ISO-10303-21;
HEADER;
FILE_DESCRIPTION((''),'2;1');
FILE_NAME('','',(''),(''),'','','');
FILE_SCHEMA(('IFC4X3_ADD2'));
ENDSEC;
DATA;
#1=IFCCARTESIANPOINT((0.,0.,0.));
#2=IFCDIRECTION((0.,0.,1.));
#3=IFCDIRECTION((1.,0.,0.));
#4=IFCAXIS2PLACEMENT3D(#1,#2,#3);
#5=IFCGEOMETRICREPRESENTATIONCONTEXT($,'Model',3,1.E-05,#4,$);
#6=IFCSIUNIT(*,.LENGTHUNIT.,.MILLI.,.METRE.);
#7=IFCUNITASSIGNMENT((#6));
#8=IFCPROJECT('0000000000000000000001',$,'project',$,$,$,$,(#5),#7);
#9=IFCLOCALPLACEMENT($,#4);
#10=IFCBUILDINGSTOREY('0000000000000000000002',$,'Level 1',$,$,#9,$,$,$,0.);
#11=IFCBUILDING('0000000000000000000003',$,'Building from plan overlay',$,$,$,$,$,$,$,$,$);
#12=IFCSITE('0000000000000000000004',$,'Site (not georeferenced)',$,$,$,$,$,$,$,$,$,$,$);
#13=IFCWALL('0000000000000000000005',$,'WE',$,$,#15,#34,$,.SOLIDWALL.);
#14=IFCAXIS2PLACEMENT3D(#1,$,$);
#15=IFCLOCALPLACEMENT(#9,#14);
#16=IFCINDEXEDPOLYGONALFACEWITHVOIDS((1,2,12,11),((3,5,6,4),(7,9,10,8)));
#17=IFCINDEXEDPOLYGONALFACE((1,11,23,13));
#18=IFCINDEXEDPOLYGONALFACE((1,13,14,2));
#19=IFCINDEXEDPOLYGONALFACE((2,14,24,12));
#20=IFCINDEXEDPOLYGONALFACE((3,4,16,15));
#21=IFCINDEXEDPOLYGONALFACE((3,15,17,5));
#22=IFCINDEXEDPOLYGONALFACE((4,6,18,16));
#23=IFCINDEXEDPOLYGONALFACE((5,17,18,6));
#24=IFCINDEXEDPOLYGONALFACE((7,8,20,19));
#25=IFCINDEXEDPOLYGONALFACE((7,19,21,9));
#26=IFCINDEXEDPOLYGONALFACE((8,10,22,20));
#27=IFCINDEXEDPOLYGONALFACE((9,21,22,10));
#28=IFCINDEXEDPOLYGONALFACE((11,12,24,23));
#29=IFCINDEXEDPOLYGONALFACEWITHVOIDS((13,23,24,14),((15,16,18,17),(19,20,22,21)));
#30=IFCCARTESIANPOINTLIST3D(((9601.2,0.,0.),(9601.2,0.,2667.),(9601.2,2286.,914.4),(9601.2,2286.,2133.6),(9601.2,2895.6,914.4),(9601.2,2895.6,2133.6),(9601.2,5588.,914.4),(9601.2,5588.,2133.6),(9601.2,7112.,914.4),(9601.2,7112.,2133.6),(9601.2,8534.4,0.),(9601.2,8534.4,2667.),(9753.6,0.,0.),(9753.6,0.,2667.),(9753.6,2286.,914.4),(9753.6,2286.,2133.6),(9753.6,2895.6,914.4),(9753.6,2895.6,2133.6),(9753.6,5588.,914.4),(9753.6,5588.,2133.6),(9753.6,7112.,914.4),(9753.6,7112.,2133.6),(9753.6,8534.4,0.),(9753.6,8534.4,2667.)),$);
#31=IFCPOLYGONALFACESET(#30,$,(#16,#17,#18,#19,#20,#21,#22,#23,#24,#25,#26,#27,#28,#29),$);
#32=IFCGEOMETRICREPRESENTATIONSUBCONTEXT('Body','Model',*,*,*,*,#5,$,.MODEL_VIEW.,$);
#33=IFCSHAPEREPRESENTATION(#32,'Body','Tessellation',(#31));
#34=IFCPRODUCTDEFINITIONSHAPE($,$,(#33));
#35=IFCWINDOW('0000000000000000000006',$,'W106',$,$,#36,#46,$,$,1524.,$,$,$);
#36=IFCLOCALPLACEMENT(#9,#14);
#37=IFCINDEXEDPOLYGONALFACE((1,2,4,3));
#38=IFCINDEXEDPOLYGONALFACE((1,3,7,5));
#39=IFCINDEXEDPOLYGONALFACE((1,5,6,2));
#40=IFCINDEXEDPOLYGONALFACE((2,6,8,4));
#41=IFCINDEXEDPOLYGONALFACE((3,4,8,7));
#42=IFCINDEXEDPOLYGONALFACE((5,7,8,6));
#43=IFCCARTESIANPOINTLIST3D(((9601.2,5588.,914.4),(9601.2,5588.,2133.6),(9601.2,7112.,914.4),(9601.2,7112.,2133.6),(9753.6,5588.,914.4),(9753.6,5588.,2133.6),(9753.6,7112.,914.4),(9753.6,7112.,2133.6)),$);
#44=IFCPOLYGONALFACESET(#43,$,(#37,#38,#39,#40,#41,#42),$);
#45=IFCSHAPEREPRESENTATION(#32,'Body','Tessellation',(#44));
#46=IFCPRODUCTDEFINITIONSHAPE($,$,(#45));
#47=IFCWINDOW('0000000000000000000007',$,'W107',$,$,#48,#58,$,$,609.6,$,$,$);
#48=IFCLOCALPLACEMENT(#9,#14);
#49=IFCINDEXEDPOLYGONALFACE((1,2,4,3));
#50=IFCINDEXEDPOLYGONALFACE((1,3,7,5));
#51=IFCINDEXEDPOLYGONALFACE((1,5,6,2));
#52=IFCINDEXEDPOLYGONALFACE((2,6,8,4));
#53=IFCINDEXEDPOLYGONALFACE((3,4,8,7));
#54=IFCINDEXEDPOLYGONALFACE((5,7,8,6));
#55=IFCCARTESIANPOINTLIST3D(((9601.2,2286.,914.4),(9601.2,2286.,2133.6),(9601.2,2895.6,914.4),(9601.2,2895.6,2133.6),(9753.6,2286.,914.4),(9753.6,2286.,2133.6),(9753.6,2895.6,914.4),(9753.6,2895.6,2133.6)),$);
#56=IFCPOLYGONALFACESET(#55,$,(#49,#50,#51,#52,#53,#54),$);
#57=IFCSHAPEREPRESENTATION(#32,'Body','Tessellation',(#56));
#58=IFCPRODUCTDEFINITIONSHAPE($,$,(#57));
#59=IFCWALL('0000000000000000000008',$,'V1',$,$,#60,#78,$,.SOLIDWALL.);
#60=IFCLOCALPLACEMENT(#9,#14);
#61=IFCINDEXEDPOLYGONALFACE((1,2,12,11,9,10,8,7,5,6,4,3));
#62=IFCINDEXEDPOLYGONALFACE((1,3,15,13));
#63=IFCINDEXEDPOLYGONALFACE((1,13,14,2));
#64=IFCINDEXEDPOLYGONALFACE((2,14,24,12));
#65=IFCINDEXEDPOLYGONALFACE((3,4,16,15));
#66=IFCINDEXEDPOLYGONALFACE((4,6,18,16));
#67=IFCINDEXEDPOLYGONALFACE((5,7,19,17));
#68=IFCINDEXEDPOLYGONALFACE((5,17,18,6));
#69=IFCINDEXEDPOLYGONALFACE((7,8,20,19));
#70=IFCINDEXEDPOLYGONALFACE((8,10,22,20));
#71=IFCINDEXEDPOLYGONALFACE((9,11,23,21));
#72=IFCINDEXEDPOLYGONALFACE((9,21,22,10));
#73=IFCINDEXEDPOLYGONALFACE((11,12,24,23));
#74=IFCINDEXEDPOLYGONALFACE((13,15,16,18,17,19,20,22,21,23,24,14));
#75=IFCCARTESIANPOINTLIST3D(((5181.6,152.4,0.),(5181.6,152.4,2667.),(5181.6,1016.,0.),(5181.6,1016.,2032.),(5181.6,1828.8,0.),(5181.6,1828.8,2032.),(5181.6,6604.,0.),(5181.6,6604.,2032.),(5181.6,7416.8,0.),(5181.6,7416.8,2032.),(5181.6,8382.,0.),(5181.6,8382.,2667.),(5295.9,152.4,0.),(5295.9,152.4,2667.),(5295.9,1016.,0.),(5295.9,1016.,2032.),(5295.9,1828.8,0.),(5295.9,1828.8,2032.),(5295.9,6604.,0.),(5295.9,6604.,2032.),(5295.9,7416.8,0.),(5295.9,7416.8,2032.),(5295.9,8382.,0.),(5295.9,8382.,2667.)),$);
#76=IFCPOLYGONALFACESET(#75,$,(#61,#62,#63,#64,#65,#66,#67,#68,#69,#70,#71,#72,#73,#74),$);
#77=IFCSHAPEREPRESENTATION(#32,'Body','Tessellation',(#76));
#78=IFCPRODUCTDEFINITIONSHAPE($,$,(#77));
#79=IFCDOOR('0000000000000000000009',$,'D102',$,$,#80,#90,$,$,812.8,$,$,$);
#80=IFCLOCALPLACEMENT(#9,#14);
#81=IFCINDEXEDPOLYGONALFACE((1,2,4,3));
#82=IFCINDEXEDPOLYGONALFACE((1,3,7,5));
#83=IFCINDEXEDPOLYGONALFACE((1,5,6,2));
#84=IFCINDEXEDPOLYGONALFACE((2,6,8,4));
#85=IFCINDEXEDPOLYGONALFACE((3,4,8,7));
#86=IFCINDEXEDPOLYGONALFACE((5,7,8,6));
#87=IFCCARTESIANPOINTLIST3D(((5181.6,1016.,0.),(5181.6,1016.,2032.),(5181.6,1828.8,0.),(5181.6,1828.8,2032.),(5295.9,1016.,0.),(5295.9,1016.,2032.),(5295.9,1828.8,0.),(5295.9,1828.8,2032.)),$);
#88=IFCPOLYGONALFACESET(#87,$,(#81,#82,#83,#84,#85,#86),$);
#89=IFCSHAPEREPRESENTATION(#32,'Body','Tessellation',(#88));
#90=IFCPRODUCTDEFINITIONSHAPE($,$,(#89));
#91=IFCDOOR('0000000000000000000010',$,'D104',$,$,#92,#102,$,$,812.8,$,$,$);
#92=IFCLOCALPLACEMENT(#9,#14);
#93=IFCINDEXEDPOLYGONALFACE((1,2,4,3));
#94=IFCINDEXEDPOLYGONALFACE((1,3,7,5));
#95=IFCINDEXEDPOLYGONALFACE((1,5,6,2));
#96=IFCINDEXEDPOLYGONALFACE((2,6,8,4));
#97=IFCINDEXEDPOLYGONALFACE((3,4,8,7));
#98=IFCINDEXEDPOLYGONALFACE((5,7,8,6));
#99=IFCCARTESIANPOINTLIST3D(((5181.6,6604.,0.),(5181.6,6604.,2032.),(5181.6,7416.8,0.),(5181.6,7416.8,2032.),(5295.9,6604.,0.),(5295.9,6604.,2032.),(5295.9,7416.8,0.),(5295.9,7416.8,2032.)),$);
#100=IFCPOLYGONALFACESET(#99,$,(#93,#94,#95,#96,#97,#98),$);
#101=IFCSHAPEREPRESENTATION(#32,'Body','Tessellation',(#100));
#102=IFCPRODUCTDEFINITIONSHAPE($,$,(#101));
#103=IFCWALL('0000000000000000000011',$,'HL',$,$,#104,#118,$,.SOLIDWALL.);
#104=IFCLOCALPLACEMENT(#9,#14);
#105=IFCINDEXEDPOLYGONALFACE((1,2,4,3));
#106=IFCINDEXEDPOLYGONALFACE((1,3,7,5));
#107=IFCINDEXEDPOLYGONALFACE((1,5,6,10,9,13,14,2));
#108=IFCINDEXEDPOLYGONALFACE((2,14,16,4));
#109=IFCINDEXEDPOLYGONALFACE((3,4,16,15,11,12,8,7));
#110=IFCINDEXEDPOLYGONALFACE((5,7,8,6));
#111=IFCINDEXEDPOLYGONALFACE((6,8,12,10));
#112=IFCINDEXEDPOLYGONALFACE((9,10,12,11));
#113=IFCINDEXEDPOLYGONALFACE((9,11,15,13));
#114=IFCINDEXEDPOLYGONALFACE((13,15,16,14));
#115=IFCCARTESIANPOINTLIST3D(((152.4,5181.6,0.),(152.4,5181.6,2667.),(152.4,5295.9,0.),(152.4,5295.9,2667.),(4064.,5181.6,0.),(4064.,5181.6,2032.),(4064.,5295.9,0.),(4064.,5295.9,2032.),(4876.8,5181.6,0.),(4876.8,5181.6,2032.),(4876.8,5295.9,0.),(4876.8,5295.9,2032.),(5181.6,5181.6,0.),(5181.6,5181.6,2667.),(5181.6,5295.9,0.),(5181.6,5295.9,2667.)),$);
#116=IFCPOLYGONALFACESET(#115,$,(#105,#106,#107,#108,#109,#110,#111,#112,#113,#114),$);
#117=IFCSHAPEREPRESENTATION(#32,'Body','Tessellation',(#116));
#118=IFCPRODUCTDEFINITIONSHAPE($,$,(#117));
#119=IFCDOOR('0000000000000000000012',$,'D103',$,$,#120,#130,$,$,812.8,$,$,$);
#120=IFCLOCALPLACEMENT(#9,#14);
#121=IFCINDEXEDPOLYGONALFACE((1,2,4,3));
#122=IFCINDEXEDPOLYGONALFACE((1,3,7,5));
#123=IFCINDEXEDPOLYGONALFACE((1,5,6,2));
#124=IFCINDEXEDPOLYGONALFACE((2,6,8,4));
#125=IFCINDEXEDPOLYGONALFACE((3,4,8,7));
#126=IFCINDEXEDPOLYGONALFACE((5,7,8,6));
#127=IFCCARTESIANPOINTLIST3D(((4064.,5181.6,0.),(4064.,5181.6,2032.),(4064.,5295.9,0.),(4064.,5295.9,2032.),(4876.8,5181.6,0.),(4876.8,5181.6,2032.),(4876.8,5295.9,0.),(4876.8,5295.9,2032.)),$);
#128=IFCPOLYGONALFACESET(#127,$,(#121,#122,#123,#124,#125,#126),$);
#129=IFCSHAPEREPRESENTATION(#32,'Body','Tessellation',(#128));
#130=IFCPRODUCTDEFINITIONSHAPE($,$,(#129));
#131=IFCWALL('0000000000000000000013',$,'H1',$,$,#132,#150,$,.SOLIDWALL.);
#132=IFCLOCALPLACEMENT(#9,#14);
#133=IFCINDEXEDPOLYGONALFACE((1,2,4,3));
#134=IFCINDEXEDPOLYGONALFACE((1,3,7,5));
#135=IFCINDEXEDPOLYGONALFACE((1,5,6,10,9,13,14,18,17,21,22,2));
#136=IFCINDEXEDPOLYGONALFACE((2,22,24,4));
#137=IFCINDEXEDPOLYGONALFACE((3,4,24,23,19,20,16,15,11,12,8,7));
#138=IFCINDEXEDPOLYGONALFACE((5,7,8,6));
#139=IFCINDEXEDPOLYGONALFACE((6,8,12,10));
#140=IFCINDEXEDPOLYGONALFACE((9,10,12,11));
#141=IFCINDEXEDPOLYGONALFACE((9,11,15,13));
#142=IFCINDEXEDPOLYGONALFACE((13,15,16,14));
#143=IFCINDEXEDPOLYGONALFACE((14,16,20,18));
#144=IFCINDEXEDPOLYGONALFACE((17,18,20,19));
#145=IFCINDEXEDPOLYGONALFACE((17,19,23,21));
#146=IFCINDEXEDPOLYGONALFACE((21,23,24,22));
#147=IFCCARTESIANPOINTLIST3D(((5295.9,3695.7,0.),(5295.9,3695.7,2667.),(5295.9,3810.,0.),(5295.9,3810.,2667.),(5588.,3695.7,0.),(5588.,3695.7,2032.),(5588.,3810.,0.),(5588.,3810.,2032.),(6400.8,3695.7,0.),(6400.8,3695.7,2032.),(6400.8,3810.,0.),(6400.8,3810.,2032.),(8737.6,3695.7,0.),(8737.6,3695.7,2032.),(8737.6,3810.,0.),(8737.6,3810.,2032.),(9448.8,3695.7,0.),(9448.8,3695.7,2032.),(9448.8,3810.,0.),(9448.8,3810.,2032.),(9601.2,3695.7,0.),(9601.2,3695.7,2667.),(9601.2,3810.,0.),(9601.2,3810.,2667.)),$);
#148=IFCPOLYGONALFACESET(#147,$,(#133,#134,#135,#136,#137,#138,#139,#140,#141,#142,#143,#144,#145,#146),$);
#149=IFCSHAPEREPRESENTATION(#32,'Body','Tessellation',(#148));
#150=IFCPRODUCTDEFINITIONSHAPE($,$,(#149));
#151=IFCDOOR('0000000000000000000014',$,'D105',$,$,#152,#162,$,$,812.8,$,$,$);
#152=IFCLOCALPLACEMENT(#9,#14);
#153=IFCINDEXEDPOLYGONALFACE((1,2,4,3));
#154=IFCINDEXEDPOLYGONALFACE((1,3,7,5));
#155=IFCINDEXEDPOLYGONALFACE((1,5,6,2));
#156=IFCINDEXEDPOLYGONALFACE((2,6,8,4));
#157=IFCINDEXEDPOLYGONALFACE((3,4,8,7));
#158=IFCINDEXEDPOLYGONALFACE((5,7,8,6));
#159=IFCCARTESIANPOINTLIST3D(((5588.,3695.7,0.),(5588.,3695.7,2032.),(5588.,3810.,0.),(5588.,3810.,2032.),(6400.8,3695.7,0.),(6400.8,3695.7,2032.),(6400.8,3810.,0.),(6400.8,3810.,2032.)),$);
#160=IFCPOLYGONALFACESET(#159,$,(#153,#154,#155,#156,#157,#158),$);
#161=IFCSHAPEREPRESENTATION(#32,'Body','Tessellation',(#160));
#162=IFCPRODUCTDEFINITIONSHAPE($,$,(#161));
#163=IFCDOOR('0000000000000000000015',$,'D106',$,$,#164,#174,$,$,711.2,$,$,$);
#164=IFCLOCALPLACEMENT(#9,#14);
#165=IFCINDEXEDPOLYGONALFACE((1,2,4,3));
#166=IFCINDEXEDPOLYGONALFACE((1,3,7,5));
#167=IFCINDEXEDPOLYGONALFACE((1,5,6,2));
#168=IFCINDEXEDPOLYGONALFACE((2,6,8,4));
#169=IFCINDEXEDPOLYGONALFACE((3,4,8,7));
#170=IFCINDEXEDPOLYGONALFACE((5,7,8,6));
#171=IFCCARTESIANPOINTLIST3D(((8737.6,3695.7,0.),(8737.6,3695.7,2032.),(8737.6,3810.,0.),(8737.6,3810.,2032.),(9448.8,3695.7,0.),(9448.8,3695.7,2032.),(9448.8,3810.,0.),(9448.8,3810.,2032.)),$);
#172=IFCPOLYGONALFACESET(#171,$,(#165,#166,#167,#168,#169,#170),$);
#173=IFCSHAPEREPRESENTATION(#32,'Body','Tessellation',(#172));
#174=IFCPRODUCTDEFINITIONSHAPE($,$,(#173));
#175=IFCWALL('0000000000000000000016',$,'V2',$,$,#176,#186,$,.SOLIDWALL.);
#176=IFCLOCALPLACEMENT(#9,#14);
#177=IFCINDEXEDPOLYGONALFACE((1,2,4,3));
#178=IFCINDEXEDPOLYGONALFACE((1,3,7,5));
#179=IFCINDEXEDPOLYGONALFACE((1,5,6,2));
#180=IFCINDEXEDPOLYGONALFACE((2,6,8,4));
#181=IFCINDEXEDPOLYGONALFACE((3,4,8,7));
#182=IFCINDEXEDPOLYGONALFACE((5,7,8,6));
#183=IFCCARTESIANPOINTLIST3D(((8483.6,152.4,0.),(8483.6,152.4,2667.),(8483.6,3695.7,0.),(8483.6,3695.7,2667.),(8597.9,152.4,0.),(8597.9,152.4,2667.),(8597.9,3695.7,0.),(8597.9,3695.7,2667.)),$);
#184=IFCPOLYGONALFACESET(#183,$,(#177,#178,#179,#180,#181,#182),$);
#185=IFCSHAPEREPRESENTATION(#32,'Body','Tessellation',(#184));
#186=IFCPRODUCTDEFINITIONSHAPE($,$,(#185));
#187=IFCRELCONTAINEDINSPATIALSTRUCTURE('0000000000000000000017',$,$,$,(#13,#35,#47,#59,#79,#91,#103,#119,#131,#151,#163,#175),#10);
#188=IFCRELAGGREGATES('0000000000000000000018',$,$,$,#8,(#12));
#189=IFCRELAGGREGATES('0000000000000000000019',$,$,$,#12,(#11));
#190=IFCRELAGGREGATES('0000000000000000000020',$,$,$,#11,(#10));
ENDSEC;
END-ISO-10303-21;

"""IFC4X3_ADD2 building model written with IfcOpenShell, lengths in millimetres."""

from ifc_helpers import new_model, si_unit, frame, origin, origin_with_axes, place, context, subcontext, project, spatial, polyline, outline, extrude, element, fill, save


model = new_model("IFC4X3_ADD2")

# Units and contexts
model_context = context("Model", 3, precision=1e-05, world=origin_with_axes())
body_context = subcontext(model_context, "Body", "Model", "MODEL_VIEW")
ifc_project = project(units=[si_unit("LENGTHUNIT", "METRE", prefix="MILLI")], contexts=[model_context])

# Site, building, storey
site = spatial("IfcSite", under=ifc_project, Name="Site (not georeferenced)")
building = spatial("IfcBuilding", under=site, Name="Building from plan overlay")
storey_placement = place(None, origin_with_axes())
storey = spatial("IfcBuildingStorey", under=building, at=storey_placement, Name="Level 1", Elevation=0.0)

# Wall, openings, windows
wall_1_placement = place(storey_placement, origin_with_axes())
wall_1 = element("IfcWall", 1, at=wall_1_placement, inside=storey, Name="WE", PredefinedType="SOLIDWALL", context=body_context, shape_type="SweptSolid", body=[
    extrude(outline(polyline([(9601.2, 0.0), (9753.6, 0.0), (9753.6, 8534.4), (9601.2, 8534.4), (9601.2, 0.0)])), origin(), (0.0, 0.0, 1.0), 2667.0),
])
opening_1_placement = place(wall_1_placement, origin_with_axes())
opening_1 = element("IfcOpeningElement", 2, at=opening_1_placement, cuts=wall_1, context=body_context, shape_type="SweptSolid", body=[
    extrude(outline(polyline([(9601.2, 5588.0), (9753.6, 5588.0), (9753.6, 7112.0), (9601.2, 7112.0), (9601.2, 5588.0)])), frame((0.0, 0.0, 914.4)), (0.0, 0.0, 1.0), 1219.2),
])
opening_2_placement = place(wall_1_placement, origin_with_axes())
opening_2 = element("IfcOpeningElement", 3, at=opening_2_placement, cuts=wall_1, context=body_context, shape_type="SweptSolid", body=[
    extrude(outline(polyline([(9601.2, 2286.0), (9753.6, 2286.0), (9753.6, 2895.6), (9601.2, 2895.6), (9601.2, 2286.0)])), frame((0.0, 0.0, 914.4)), (0.0, 0.0, 1.0), 1219.2),
])
window_1_placement = place(storey_placement, origin_with_axes())
window_1 = element("IfcWindow", 4, at=window_1_placement, inside=storey, Name="W106", OverallWidth=1524.0, context=body_context, shape_type="SweptSolid", body=[
    extrude(outline(polyline([(9601.2, 5588.0), (9753.6, 5588.0), (9753.6, 7112.0), (9601.2, 7112.0), (9601.2, 5588.0)])), frame((0.0, 0.0, 914.4)), (0.0, 0.0, 1.0), 1219.2),
])
fill(opening_1, window_1)
window_2_placement = place(storey_placement, origin_with_axes())
window_2 = element("IfcWindow", 5, at=window_2_placement, inside=storey, Name="W107", OverallWidth=609.6, context=body_context, shape_type="SweptSolid", body=[
    extrude(outline(polyline([(9601.2, 2286.0), (9753.6, 2286.0), (9753.6, 2895.6), (9601.2, 2895.6), (9601.2, 2286.0)])), frame((0.0, 0.0, 914.4)), (0.0, 0.0, 1.0), 1219.2),
])
fill(opening_2, window_2)

# Wall, openings, doors
wall_2_placement = place(storey_placement, origin_with_axes())
wall_2 = element("IfcWall", 6, at=wall_2_placement, inside=storey, Name="V1", PredefinedType="SOLIDWALL", context=body_context, shape_type="SweptSolid", body=[
    extrude(outline(polyline([(5181.6, 152.4), (5295.9, 152.4), (5295.9, 8382.0), (5181.6, 8382.0), (5181.6, 152.4)])), origin(), (0.0, 0.0, 1.0), 2667.0),
])
opening_3_placement = place(wall_2_placement, origin_with_axes())
opening_3 = element("IfcOpeningElement", 7, at=opening_3_placement, cuts=wall_2, context=body_context, shape_type="SweptSolid", body=[
    extrude(outline(polyline([(5181.6, 1016.0), (5295.9, 1016.0), (5295.9, 1828.8), (5181.6, 1828.8), (5181.6, 1016.0)])), origin(), (0.0, 0.0, 1.0), 2032.0),
])
opening_4_placement = place(wall_2_placement, origin_with_axes())
opening_4 = element("IfcOpeningElement", 8, at=opening_4_placement, cuts=wall_2, context=body_context, shape_type="SweptSolid", body=[
    extrude(outline(polyline([(5181.6, 6604.0), (5295.9, 6604.0), (5295.9, 7416.8), (5181.6, 7416.8), (5181.6, 6604.0)])), origin(), (0.0, 0.0, 1.0), 2032.0),
])
door_1_placement = place(storey_placement, origin_with_axes())
door_1 = element("IfcDoor", 9, at=door_1_placement, inside=storey, Name="D102", OverallWidth=812.8, context=body_context, shape_type="SweptSolid", body=[
    extrude(outline(polyline([(5181.6, 1016.0), (5295.9, 1016.0), (5295.9, 1828.8), (5181.6, 1828.8), (5181.6, 1016.0)])), origin(), (0.0, 0.0, 1.0), 2032.0),
])
fill(opening_3, door_1)
door_2_placement = place(storey_placement, origin_with_axes())
door_2 = element("IfcDoor", 10, at=door_2_placement, inside=storey, Name="D104", OverallWidth=812.8, context=body_context, shape_type="SweptSolid", body=[
    extrude(outline(polyline([(5181.6, 6604.0), (5295.9, 6604.0), (5295.9, 7416.8), (5181.6, 7416.8), (5181.6, 6604.0)])), origin(), (0.0, 0.0, 1.0), 2032.0),
])
fill(opening_4, door_2)

# Wall, opening, door
wall_3_placement = place(storey_placement, origin_with_axes())
wall_3 = element("IfcWall", 11, at=wall_3_placement, inside=storey, Name="HL", PredefinedType="SOLIDWALL", context=body_context, shape_type="SweptSolid", body=[
    extrude(outline(polyline([(152.4, 5181.6), (5181.6, 5181.6), (5181.6, 5295.9), (152.4, 5295.9), (152.4, 5181.6)])), origin(), (0.0, 0.0, 1.0), 2667.0),
])
opening_5_placement = place(wall_3_placement, origin_with_axes())
opening_5 = element("IfcOpeningElement", 12, at=opening_5_placement, cuts=wall_3, context=body_context, shape_type="SweptSolid", body=[
    extrude(outline(polyline([(4064.0, 5181.6), (4876.8, 5181.6), (4876.8, 5295.9), (4064.0, 5295.9), (4064.0, 5181.6)])), origin(), (0.0, 0.0, 1.0), 2032.0),
])
door_3_placement = place(storey_placement, origin_with_axes())
door_3 = element("IfcDoor", 13, at=door_3_placement, inside=storey, Name="D103", OverallWidth=812.8, context=body_context, shape_type="SweptSolid", body=[
    extrude(outline(polyline([(4064.0, 5181.6), (4876.8, 5181.6), (4876.8, 5295.9), (4064.0, 5295.9), (4064.0, 5181.6)])), origin(), (0.0, 0.0, 1.0), 2032.0),
])
fill(opening_5, door_3)

# Wall, openings, doors
wall_4_placement = place(storey_placement, origin_with_axes())
wall_4 = element("IfcWall", 14, at=wall_4_placement, inside=storey, Name="H1", PredefinedType="SOLIDWALL", context=body_context, shape_type="SweptSolid", body=[
    extrude(outline(polyline([(5295.9, 3695.7), (9601.2, 3695.7), (9601.2, 3810.0), (5295.9, 3810.0), (5295.9, 3695.7)])), origin(), (0.0, 0.0, 1.0), 2667.0),
])
opening_6_placement = place(wall_4_placement, origin_with_axes())
opening_6 = element("IfcOpeningElement", 15, at=opening_6_placement, cuts=wall_4, context=body_context, shape_type="SweptSolid", body=[
    extrude(outline(polyline([(5588.0, 3695.7), (6400.8, 3695.7), (6400.8, 3810.0), (5588.0, 3810.0), (5588.0, 3695.7)])), origin(), (0.0, 0.0, 1.0), 2032.0),
])
opening_7_placement = place(wall_4_placement, origin_with_axes())
opening_7 = element("IfcOpeningElement", 16, at=opening_7_placement, cuts=wall_4, context=body_context, shape_type="SweptSolid", body=[
    extrude(outline(polyline([(8737.6, 3695.7), (9448.8, 3695.7), (9448.8, 3810.0), (8737.6, 3810.0), (8737.6, 3695.7)])), origin(), (0.0, 0.0, 1.0), 2032.0),
])
door_4_placement = place(storey_placement, origin_with_axes())
door_4 = element("IfcDoor", 17, at=door_4_placement, inside=storey, Name="D105", OverallWidth=812.8, context=body_context, shape_type="SweptSolid", body=[
    extrude(outline(polyline([(5588.0, 3695.7), (6400.8, 3695.7), (6400.8, 3810.0), (5588.0, 3810.0), (5588.0, 3695.7)])), origin(), (0.0, 0.0, 1.0), 2032.0),
])
fill(opening_6, door_4)
door_5_placement = place(storey_placement, origin_with_axes())
door_5 = element("IfcDoor", 18, at=door_5_placement, inside=storey, Name="D106", OverallWidth=711.2, context=body_context, shape_type="SweptSolid", body=[
    extrude(outline(polyline([(8737.6, 3695.7), (9448.8, 3695.7), (9448.8, 3810.0), (8737.6, 3810.0), (8737.6, 3695.7)])), origin(), (0.0, 0.0, 1.0), 2032.0),
])
fill(opening_7, door_5)

# Wall
wall_5_placement = place(storey_placement, origin_with_axes())
element("IfcWall", 19, at=wall_5_placement, inside=storey, Name="V2", PredefinedType="SOLIDWALL", context=body_context, shape_type="SweptSolid", body=[
    extrude(outline(polyline([(8483.6, 152.4), (8597.9, 152.4), (8597.9, 3695.7), (8483.6, 3695.7), (8483.6, 152.4)])), origin(), (0.0, 0.0, 1.0), 2667.0),
])

save(model, "model.ifc")
